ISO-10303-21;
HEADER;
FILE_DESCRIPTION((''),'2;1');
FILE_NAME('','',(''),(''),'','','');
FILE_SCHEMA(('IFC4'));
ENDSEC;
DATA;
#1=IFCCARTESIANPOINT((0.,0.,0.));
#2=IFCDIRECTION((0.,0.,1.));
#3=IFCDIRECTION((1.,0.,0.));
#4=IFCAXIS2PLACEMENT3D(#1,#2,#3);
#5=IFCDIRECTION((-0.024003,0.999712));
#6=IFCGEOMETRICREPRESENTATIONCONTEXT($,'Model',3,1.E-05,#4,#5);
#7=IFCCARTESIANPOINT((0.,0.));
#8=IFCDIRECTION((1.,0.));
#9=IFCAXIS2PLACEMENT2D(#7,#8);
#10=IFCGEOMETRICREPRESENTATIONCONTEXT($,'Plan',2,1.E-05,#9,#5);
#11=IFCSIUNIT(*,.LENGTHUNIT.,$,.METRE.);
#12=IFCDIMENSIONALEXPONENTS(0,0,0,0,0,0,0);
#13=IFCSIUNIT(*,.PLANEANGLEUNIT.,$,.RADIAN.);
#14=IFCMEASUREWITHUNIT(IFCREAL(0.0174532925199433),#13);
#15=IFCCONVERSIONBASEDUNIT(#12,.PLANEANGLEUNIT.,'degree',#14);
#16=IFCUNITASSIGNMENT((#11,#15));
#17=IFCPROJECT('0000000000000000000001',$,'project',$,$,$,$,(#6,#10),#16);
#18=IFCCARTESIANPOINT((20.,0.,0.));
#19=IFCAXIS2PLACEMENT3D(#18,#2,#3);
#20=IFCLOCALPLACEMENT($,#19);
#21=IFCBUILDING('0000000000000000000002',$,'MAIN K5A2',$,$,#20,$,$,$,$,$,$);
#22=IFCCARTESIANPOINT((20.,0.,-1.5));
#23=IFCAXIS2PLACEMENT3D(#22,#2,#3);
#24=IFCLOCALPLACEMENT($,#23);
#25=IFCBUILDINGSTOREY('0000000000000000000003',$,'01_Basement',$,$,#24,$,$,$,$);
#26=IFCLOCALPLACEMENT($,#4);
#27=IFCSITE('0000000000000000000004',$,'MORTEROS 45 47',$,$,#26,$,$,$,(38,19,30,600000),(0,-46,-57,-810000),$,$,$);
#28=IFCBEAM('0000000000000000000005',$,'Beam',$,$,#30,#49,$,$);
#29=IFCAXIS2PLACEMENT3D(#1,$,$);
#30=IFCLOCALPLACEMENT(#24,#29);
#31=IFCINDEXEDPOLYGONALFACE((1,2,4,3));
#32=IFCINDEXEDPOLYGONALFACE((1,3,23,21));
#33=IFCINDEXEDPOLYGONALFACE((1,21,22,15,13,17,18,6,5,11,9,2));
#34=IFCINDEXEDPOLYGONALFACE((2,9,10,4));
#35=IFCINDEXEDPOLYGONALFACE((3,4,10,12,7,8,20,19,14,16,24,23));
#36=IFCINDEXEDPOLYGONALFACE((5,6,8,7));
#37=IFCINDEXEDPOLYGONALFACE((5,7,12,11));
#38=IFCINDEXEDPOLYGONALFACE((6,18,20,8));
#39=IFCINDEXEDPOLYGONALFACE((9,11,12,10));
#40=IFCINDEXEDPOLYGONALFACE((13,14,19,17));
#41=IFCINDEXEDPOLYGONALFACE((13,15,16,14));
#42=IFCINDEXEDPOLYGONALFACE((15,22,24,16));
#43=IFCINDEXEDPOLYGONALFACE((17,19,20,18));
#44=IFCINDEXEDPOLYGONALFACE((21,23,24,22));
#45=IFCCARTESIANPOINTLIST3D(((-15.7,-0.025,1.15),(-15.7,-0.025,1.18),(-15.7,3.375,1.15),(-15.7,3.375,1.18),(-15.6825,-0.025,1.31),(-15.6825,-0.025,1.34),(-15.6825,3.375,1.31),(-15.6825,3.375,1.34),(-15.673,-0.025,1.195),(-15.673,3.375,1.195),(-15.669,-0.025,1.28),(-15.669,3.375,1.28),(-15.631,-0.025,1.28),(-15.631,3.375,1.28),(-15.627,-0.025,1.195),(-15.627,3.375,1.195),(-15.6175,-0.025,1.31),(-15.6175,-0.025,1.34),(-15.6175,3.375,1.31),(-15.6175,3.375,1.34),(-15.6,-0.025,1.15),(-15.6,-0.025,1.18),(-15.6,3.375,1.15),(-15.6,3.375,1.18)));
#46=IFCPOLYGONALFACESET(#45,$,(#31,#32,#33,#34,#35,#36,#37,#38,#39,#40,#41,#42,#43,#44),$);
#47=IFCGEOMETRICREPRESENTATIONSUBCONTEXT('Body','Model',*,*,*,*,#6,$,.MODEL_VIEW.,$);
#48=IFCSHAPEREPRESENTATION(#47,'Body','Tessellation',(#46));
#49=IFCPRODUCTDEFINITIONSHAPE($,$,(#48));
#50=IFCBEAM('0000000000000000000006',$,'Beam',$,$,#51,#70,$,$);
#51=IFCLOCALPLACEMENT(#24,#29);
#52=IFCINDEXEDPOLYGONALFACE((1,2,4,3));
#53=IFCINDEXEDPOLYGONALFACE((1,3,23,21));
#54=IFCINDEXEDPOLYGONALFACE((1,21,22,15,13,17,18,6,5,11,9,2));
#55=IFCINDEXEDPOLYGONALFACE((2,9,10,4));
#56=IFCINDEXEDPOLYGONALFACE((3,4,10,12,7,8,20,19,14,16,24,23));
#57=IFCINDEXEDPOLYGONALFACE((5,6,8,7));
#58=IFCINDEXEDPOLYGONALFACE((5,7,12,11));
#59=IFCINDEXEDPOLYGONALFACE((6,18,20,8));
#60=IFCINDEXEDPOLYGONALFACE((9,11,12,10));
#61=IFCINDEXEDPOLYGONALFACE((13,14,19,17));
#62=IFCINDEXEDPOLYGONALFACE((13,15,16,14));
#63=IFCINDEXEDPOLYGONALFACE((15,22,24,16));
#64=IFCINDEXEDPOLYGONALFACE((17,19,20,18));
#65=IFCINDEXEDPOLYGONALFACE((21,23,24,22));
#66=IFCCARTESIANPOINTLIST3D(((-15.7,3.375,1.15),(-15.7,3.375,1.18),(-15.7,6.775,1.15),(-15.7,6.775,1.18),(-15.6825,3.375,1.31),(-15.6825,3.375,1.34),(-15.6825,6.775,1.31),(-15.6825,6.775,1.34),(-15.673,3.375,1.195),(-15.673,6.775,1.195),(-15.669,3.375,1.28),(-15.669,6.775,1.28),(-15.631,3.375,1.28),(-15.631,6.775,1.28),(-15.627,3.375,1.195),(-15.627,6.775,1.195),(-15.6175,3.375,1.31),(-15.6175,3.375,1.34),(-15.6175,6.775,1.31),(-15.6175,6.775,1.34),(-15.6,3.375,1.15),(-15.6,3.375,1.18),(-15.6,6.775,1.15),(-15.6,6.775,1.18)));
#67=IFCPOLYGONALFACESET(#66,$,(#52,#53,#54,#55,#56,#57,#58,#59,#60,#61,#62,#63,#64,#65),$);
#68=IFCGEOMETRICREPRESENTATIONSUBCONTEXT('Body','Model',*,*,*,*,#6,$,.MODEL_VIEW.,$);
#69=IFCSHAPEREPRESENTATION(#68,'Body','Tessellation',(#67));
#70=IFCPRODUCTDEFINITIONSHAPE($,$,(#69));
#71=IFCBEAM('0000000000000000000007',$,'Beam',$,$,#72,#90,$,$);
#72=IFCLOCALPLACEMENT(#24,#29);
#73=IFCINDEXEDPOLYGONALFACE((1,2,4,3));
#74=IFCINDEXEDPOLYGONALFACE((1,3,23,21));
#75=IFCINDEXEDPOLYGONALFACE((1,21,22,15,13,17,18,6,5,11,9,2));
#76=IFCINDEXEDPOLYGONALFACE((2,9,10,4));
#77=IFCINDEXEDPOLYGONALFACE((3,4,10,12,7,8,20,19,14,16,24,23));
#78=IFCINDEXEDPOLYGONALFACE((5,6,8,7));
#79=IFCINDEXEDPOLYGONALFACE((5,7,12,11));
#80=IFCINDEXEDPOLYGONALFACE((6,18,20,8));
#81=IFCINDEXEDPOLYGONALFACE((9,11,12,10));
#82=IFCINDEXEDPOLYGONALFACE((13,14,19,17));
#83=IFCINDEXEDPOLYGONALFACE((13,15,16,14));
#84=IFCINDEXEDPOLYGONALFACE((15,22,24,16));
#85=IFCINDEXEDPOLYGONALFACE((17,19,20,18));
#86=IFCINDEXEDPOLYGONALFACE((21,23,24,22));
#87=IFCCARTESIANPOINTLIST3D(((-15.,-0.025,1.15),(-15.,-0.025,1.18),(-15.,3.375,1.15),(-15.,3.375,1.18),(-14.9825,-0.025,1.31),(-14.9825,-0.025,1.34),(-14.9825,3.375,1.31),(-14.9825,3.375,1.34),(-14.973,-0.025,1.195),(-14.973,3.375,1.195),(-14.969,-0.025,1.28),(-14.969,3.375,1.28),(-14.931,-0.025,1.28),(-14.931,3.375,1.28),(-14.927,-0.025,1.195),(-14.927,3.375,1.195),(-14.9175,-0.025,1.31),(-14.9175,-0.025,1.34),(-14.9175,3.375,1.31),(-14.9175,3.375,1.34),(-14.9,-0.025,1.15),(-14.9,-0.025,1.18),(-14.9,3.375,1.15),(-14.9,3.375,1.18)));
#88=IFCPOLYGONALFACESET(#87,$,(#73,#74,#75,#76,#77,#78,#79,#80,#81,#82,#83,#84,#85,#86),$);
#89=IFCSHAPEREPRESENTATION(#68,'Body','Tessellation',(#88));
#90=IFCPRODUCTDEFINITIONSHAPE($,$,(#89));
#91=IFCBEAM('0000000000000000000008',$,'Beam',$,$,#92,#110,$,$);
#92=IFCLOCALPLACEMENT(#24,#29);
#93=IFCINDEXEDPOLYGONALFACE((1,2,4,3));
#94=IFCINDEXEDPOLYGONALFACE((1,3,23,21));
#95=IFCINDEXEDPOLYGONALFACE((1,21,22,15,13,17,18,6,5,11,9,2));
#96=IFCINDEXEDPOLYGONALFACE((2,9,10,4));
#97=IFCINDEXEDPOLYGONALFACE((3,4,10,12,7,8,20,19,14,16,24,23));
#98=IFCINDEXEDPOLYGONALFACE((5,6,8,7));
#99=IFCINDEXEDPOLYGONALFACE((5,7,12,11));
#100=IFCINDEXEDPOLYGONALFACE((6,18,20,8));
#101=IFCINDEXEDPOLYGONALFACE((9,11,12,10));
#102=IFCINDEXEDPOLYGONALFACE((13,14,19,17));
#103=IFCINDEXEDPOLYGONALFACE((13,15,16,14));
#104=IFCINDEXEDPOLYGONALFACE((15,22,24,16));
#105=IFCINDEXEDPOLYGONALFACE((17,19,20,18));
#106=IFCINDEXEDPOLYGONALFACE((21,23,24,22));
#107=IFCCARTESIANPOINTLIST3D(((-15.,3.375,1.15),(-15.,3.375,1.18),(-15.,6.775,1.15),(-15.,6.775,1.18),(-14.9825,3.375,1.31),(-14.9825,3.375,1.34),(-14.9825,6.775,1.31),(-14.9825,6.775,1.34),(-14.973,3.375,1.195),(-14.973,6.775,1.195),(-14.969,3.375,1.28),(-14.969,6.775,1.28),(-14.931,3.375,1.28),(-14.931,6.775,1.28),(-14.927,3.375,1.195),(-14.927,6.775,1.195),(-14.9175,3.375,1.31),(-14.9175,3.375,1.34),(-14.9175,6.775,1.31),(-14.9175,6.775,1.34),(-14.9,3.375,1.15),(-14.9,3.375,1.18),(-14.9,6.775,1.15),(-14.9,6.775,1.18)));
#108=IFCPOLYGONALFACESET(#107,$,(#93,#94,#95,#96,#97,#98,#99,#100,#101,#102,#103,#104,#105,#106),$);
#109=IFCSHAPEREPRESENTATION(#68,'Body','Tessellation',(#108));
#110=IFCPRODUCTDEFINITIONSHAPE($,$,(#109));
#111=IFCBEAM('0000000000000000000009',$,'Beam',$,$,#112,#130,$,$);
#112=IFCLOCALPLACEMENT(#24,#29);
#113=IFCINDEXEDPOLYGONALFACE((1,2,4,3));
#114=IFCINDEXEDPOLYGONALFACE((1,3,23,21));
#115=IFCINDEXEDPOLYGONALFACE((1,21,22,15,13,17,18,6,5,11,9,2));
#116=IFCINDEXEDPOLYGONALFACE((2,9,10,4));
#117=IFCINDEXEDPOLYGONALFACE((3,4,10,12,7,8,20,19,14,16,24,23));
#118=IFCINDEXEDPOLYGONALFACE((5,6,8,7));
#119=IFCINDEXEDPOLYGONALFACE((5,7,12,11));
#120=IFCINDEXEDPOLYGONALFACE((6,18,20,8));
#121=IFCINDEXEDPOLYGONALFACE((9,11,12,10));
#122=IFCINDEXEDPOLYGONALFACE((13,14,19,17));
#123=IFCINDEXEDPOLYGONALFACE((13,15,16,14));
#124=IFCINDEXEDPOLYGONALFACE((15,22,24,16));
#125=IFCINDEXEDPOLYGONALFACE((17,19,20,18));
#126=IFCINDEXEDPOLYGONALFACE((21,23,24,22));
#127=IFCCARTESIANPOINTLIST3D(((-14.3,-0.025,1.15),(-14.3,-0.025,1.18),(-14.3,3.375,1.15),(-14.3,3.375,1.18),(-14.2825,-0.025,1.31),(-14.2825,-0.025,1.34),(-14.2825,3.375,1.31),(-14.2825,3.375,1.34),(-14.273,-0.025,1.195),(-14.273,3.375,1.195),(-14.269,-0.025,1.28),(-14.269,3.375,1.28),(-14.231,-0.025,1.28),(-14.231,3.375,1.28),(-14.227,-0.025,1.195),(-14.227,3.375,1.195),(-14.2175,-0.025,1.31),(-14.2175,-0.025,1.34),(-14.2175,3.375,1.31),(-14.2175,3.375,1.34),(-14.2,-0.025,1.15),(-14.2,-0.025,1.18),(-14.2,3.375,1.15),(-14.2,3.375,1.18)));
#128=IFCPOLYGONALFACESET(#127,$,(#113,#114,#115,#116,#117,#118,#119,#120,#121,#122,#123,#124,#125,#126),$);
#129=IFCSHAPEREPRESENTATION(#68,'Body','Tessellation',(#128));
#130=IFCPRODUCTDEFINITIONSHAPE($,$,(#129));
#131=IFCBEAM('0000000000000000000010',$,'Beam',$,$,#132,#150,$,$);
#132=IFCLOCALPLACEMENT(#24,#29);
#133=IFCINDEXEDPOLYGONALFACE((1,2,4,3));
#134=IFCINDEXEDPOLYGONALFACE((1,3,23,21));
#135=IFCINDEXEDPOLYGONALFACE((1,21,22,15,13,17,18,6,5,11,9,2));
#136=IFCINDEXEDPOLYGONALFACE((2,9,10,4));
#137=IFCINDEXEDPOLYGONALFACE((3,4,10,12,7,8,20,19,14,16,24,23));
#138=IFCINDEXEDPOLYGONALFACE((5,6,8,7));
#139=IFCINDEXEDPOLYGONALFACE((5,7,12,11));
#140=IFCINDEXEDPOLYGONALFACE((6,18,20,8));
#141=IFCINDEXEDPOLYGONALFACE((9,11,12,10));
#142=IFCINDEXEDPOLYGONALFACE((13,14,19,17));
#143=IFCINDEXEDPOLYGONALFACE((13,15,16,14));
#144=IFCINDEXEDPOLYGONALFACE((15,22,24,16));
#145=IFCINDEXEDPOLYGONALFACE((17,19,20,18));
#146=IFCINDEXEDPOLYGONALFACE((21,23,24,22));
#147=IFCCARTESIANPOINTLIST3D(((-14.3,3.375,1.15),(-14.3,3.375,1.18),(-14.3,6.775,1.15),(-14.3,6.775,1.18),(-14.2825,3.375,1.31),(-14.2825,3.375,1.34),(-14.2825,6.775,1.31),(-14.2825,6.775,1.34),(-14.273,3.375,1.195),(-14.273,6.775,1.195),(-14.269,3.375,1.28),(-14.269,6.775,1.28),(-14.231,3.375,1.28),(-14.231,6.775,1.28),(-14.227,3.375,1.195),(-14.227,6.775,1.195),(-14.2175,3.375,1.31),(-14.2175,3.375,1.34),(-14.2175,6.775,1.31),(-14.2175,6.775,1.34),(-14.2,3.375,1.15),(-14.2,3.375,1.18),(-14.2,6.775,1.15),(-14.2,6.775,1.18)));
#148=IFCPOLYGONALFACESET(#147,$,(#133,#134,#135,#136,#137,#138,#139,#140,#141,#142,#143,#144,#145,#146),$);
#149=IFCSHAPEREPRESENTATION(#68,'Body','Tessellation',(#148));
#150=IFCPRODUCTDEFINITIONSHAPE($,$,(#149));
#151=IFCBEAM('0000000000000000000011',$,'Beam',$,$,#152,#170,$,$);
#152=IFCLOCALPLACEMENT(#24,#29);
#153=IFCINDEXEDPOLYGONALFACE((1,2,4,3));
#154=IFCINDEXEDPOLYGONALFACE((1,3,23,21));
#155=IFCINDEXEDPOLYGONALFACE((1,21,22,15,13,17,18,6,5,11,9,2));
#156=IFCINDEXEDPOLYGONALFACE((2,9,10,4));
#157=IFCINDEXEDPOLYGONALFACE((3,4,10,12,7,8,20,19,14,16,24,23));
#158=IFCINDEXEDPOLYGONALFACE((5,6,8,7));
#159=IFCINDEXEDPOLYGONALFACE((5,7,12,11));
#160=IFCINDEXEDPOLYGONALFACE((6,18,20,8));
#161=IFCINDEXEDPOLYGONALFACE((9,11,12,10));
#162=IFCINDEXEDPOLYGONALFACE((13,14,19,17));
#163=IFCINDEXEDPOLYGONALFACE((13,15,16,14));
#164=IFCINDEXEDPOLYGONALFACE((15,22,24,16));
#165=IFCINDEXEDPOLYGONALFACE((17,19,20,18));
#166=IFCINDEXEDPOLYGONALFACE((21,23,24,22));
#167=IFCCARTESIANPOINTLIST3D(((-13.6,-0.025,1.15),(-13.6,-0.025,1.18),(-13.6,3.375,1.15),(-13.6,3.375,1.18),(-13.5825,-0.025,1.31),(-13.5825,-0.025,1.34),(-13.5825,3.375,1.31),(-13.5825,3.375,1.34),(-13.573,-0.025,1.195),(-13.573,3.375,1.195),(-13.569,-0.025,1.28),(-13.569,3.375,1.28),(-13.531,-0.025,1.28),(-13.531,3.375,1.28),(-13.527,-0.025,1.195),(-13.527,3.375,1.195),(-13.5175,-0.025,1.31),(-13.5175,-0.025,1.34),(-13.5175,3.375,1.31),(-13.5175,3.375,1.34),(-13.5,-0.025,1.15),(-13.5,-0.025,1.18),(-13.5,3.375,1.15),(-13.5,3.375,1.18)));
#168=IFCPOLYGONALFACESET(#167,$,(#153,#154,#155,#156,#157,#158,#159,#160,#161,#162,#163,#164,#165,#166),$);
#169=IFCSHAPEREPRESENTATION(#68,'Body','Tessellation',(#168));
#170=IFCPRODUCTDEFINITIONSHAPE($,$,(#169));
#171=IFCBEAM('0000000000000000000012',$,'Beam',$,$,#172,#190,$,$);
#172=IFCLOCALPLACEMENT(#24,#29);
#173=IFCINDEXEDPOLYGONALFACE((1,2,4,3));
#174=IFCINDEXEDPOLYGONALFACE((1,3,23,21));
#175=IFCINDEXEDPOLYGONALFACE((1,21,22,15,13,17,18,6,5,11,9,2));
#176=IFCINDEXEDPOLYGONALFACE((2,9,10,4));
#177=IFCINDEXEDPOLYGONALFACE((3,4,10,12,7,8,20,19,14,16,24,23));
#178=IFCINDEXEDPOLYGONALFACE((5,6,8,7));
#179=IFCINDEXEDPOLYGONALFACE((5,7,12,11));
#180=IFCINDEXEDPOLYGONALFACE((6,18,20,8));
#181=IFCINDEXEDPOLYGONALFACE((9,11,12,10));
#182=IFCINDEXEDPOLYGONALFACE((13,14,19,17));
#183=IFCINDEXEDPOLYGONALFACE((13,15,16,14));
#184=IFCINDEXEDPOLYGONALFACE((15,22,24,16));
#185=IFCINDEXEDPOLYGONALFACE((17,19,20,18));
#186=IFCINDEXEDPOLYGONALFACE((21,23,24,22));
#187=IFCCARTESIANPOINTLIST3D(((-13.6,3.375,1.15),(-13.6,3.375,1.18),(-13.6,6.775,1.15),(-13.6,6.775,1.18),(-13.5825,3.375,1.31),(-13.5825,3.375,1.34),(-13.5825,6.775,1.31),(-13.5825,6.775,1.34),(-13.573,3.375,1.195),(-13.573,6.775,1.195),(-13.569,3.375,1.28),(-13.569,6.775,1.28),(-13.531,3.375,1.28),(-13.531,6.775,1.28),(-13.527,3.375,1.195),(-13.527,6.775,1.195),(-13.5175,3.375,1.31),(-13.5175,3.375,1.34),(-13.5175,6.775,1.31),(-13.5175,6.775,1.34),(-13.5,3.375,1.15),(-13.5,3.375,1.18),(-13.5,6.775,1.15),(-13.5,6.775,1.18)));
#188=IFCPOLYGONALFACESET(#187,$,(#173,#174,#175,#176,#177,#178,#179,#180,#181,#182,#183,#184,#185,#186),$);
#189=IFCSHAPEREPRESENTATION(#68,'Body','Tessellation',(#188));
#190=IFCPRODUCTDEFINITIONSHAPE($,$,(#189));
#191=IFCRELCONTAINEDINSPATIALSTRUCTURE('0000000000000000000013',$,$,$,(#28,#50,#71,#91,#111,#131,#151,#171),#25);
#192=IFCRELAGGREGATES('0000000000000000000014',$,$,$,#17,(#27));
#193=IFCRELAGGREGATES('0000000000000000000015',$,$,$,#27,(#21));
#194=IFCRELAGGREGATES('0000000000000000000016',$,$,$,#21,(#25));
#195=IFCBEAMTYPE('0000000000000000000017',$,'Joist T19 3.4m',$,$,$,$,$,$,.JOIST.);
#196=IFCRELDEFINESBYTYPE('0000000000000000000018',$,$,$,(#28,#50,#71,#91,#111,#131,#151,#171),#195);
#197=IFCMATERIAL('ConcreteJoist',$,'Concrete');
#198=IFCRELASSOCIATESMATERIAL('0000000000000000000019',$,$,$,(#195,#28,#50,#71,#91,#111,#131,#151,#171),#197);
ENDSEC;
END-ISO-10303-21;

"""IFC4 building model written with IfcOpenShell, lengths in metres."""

from ifc_helpers import new_model, entity, si_unit, converted_unit, direction, frame, origin_with_axes, origin_2d_with_axis, place, context, subcontext, project, spatial, indexed_curve, outline, extrude, material, material_profile, profile_set, profile_usage, type_object, element, save


model = new_model("IFC4")

# Units and contexts
model_context = context("Model", 3, precision=1e-05, world=origin_with_axes(), true_north=direction((-0.024003, 0.999712)))
plan_context = context("Plan", 2, precision=1e-05, world=origin_2d_with_axis(), true_north=direction((-0.024003, 0.999712)))
body_context_1 = subcontext(model_context, "Body", "Model", "MODEL_VIEW")
body_context_2 = subcontext(model_context, "Body", "Model", "MODEL_VIEW")
ifc_project = project(units=[si_unit("LENGTHUNIT", "METRE"), converted_unit("PLANEANGLEUNIT", "degree", entity("IfcReal", 0.0174532925199433), si_unit("PLANEANGLEUNIT", "RADIAN"), dimensions=[0, 0, 0, 0, 0, 0, 0])], contexts=[model_context, plan_context])

# Site, building, storey
site_placement = place(None, origin_with_axes())
site = spatial("IfcSite", under=ifc_project, at=site_placement, Name="MORTEROS 45 47", RefLatitude=(38, 19, 30, 600000), RefLongitude=(0, -46, -57, -810000))
building_placement = place(None, frame((20.0, 0.0, 0.0), z_axis=(0.0, 0.0, 1.0), x_axis=(1.0, 0.0, 0.0)))
building = spatial("IfcBuilding", under=site, at=building_placement, Name="MAIN K5A2")
storey_placement = place(None, frame((20.0, 0.0, -1.5), z_axis=(0.0, 0.0, 1.0), x_axis=(1.0, 0.0, 0.0)))
storey = spatial("IfcBuildingStorey", under=building, at=storey_placement, Name="01_Basement")

# Beams
ifc_material = material(Name="ConcreteJoist", Category="Concrete")
ifc_material_profile = material_profile(ifc_material, outline(indexed_curve([(0.019, 0.13), (0.023, 0.045), (0.05, 0.03), (0.05, 0.0), (-0.05, 0.0), (-0.05, 0.03), (-0.023, 0.045), (-0.019, 0.13), (-0.0325, 0.16), (-0.0325, 0.19), (0.0325, 0.19), (0.0325, 0.16), (0.019, 0.13)])))
ifc_profile_set = profile_set([ifc_material_profile], Name="JoistMaterialProfileSet")
ifc_profile_usage_1 = profile_usage(ifc_profile_set, cardinal=5)
beam_type = type_object("IfcBeamType", Name="Joist T19 3.4m", PredefinedType="JOIST", material=ifc_profile_set)
beam_1_placement = place(None, frame((4.35, -0.025, -0.35), z_axis=(0.0, 1.0, 0.0), x_axis=(-1.0, 0.0, 0.0)))
element("IfcBeam", 1, at=beam_1_placement, inside=storey, type_object=beam_type, material=ifc_profile_usage_1, Name="Beam", context=body_context_2, shape_type="SweptSolid", body=[
    extrude(outline(indexed_curve([(0.019, 0.13), (0.023, 0.045), (0.05, 0.03), (0.05, 0.0), (-0.05, 0.0), (-0.05, 0.03), (-0.023, 0.045), (-0.019, 0.13), (-0.0325, 0.16), (-0.0325, 0.19), (0.0325, 0.19), (0.0325, 0.16), (0.019, 0.13)])), origin_with_axes(), (0.0, 0.0, 1.0), 3.4),
])
ifc_profile_usage_2 = profile_usage(ifc_profile_set, cardinal=5)
beam_2_placement = place(None, frame((4.35, 3.375, -0.35), z_axis=(0.0, 1.0, 0.0), x_axis=(-1.0, 0.0, 0.0)))
element("IfcBeam", 2, at=beam_2_placement, inside=storey, type_object=beam_type, material=ifc_profile_usage_2, Name="Beam", context=body_context_1, shape_type="SweptSolid", body=[
    extrude(outline(indexed_curve([(0.019, 0.13), (0.023, 0.045), (0.05, 0.03), (0.05, 0.0), (-0.05, 0.0), (-0.05, 0.03), (-0.023, 0.045), (-0.019, 0.13), (-0.0325, 0.16), (-0.0325, 0.19), (0.0325, 0.19), (0.0325, 0.16), (0.019, 0.13)])), origin_with_axes(), (0.0, 0.0, 1.0), 3.4),
])
ifc_profile_usage_3 = profile_usage(ifc_profile_set, cardinal=5)
beam_3_placement = place(None, frame((5.05, -0.025, -0.35), z_axis=(0.0, 1.0, 0.0), x_axis=(-1.0, 0.0, 0.0)))
element("IfcBeam", 3, at=beam_3_placement, inside=storey, type_object=beam_type, material=ifc_profile_usage_3, Name="Beam", context=body_context_1, shape_type="SweptSolid", body=[
    extrude(outline(indexed_curve([(0.019, 0.13), (0.023, 0.045), (0.05, 0.03), (0.05, 0.0), (-0.05, 0.0), (-0.05, 0.03), (-0.023, 0.045), (-0.019, 0.13), (-0.0325, 0.16), (-0.0325, 0.19), (0.0325, 0.19), (0.0325, 0.16), (0.019, 0.13)])), origin_with_axes(), (0.0, 0.0, 1.0), 3.4),
])
ifc_profile_usage_4 = profile_usage(ifc_profile_set, cardinal=5)
beam_4_placement = place(None, frame((5.05, 3.375, -0.35), z_axis=(0.0, 1.0, 0.0), x_axis=(-1.0, 0.0, 0.0)))
element("IfcBeam", 4, at=beam_4_placement, inside=storey, type_object=beam_type, material=ifc_profile_usage_4, Name="Beam", context=body_context_1, shape_type="SweptSolid", body=[
    extrude(outline(indexed_curve([(0.019, 0.13), (0.023, 0.045), (0.05, 0.03), (0.05, 0.0), (-0.05, 0.0), (-0.05, 0.03), (-0.023, 0.045), (-0.019, 0.13), (-0.0325, 0.16), (-0.0325, 0.19), (0.0325, 0.19), (0.0325, 0.16), (0.019, 0.13)])), origin_with_axes(), (0.0, 0.0, 1.0), 3.4),
])
ifc_profile_usage_5 = profile_usage(ifc_profile_set, cardinal=5)
beam_5_placement = place(None, frame((5.75, -0.025, -0.35), z_axis=(0.0, 1.0, 0.0), x_axis=(-1.0, 0.0, 0.0)))
element("IfcBeam", 5, at=beam_5_placement, inside=storey, type_object=beam_type, material=ifc_profile_usage_5, Name="Beam", context=body_context_1, shape_type="SweptSolid", body=[
    extrude(outline(indexed_curve([(0.019, 0.13), (0.023, 0.045), (0.05, 0.03), (0.05, 0.0), (-0.05, 0.0), (-0.05, 0.03), (-0.023, 0.045), (-0.019, 0.13), (-0.0325, 0.16), (-0.0325, 0.19), (0.0325, 0.19), (0.0325, 0.16), (0.019, 0.13)])), origin_with_axes(), (0.0, 0.0, 1.0), 3.4),
])
ifc_profile_usage_6 = profile_usage(ifc_profile_set, cardinal=5)
beam_6_placement = place(None, frame((5.75, 3.375, -0.35), z_axis=(0.0, 1.0, 0.0), x_axis=(-1.0, 0.0, 0.0)))
element("IfcBeam", 6, at=beam_6_placement, inside=storey, type_object=beam_type, material=ifc_profile_usage_6, Name="Beam", context=body_context_1, shape_type="SweptSolid", body=[
    extrude(outline(indexed_curve([(0.019, 0.13), (0.023, 0.045), (0.05, 0.03), (0.05, 0.0), (-0.05, 0.0), (-0.05, 0.03), (-0.023, 0.045), (-0.019, 0.13), (-0.0325, 0.16), (-0.0325, 0.19), (0.0325, 0.19), (0.0325, 0.16), (0.019, 0.13)])), origin_with_axes(), (0.0, 0.0, 1.0), 3.4),
])
ifc_profile_usage_7 = profile_usage(ifc_profile_set, cardinal=5)
beam_7_placement = place(None, frame((6.45, -0.025, -0.35), z_axis=(0.0, 1.0, 0.0), x_axis=(-1.0, 0.0, 0.0)))
element("IfcBeam", 7, at=beam_7_placement, inside=storey, type_object=beam_type, material=ifc_profile_usage_7, Name="Beam", context=body_context_1, shape_type="SweptSolid", body=[
    extrude(outline(indexed_curve([(0.019, 0.13), (0.023, 0.045), (0.05, 0.03), (0.05, 0.0), (-0.05, 0.0), (-0.05, 0.03), (-0.023, 0.045), (-0.019, 0.13), (-0.0325, 0.16), (-0.0325, 0.19), (0.0325, 0.19), (0.0325, 0.16), (0.019, 0.13)])), origin_with_axes(), (0.0, 0.0, 1.0), 3.4),
])
ifc_profile_usage_8 = profile_usage(ifc_profile_set, cardinal=5)
beam_8_placement = place(None, frame((6.45, 3.375, -0.35), z_axis=(0.0, 1.0, 0.0), x_axis=(-1.0, 0.0, 0.0)))
element("IfcBeam", 8, at=beam_8_placement, inside=storey, type_object=beam_type, material=ifc_profile_usage_8, Name="Beam", context=body_context_1, shape_type="SweptSolid", body=[
    extrude(outline(indexed_curve([(0.019, 0.13), (0.023, 0.045), (0.05, 0.03), (0.05, 0.0), (-0.05, 0.0), (-0.05, 0.03), (-0.023, 0.045), (-0.019, 0.13), (-0.0325, 0.16), (-0.0325, 0.19), (0.0325, 0.19), (0.0325, 0.16), (0.019, 0.13)])), origin_with_axes(), (0.0, 0.0, 1.0), 3.4),
])

save(model, "model.ifc")
